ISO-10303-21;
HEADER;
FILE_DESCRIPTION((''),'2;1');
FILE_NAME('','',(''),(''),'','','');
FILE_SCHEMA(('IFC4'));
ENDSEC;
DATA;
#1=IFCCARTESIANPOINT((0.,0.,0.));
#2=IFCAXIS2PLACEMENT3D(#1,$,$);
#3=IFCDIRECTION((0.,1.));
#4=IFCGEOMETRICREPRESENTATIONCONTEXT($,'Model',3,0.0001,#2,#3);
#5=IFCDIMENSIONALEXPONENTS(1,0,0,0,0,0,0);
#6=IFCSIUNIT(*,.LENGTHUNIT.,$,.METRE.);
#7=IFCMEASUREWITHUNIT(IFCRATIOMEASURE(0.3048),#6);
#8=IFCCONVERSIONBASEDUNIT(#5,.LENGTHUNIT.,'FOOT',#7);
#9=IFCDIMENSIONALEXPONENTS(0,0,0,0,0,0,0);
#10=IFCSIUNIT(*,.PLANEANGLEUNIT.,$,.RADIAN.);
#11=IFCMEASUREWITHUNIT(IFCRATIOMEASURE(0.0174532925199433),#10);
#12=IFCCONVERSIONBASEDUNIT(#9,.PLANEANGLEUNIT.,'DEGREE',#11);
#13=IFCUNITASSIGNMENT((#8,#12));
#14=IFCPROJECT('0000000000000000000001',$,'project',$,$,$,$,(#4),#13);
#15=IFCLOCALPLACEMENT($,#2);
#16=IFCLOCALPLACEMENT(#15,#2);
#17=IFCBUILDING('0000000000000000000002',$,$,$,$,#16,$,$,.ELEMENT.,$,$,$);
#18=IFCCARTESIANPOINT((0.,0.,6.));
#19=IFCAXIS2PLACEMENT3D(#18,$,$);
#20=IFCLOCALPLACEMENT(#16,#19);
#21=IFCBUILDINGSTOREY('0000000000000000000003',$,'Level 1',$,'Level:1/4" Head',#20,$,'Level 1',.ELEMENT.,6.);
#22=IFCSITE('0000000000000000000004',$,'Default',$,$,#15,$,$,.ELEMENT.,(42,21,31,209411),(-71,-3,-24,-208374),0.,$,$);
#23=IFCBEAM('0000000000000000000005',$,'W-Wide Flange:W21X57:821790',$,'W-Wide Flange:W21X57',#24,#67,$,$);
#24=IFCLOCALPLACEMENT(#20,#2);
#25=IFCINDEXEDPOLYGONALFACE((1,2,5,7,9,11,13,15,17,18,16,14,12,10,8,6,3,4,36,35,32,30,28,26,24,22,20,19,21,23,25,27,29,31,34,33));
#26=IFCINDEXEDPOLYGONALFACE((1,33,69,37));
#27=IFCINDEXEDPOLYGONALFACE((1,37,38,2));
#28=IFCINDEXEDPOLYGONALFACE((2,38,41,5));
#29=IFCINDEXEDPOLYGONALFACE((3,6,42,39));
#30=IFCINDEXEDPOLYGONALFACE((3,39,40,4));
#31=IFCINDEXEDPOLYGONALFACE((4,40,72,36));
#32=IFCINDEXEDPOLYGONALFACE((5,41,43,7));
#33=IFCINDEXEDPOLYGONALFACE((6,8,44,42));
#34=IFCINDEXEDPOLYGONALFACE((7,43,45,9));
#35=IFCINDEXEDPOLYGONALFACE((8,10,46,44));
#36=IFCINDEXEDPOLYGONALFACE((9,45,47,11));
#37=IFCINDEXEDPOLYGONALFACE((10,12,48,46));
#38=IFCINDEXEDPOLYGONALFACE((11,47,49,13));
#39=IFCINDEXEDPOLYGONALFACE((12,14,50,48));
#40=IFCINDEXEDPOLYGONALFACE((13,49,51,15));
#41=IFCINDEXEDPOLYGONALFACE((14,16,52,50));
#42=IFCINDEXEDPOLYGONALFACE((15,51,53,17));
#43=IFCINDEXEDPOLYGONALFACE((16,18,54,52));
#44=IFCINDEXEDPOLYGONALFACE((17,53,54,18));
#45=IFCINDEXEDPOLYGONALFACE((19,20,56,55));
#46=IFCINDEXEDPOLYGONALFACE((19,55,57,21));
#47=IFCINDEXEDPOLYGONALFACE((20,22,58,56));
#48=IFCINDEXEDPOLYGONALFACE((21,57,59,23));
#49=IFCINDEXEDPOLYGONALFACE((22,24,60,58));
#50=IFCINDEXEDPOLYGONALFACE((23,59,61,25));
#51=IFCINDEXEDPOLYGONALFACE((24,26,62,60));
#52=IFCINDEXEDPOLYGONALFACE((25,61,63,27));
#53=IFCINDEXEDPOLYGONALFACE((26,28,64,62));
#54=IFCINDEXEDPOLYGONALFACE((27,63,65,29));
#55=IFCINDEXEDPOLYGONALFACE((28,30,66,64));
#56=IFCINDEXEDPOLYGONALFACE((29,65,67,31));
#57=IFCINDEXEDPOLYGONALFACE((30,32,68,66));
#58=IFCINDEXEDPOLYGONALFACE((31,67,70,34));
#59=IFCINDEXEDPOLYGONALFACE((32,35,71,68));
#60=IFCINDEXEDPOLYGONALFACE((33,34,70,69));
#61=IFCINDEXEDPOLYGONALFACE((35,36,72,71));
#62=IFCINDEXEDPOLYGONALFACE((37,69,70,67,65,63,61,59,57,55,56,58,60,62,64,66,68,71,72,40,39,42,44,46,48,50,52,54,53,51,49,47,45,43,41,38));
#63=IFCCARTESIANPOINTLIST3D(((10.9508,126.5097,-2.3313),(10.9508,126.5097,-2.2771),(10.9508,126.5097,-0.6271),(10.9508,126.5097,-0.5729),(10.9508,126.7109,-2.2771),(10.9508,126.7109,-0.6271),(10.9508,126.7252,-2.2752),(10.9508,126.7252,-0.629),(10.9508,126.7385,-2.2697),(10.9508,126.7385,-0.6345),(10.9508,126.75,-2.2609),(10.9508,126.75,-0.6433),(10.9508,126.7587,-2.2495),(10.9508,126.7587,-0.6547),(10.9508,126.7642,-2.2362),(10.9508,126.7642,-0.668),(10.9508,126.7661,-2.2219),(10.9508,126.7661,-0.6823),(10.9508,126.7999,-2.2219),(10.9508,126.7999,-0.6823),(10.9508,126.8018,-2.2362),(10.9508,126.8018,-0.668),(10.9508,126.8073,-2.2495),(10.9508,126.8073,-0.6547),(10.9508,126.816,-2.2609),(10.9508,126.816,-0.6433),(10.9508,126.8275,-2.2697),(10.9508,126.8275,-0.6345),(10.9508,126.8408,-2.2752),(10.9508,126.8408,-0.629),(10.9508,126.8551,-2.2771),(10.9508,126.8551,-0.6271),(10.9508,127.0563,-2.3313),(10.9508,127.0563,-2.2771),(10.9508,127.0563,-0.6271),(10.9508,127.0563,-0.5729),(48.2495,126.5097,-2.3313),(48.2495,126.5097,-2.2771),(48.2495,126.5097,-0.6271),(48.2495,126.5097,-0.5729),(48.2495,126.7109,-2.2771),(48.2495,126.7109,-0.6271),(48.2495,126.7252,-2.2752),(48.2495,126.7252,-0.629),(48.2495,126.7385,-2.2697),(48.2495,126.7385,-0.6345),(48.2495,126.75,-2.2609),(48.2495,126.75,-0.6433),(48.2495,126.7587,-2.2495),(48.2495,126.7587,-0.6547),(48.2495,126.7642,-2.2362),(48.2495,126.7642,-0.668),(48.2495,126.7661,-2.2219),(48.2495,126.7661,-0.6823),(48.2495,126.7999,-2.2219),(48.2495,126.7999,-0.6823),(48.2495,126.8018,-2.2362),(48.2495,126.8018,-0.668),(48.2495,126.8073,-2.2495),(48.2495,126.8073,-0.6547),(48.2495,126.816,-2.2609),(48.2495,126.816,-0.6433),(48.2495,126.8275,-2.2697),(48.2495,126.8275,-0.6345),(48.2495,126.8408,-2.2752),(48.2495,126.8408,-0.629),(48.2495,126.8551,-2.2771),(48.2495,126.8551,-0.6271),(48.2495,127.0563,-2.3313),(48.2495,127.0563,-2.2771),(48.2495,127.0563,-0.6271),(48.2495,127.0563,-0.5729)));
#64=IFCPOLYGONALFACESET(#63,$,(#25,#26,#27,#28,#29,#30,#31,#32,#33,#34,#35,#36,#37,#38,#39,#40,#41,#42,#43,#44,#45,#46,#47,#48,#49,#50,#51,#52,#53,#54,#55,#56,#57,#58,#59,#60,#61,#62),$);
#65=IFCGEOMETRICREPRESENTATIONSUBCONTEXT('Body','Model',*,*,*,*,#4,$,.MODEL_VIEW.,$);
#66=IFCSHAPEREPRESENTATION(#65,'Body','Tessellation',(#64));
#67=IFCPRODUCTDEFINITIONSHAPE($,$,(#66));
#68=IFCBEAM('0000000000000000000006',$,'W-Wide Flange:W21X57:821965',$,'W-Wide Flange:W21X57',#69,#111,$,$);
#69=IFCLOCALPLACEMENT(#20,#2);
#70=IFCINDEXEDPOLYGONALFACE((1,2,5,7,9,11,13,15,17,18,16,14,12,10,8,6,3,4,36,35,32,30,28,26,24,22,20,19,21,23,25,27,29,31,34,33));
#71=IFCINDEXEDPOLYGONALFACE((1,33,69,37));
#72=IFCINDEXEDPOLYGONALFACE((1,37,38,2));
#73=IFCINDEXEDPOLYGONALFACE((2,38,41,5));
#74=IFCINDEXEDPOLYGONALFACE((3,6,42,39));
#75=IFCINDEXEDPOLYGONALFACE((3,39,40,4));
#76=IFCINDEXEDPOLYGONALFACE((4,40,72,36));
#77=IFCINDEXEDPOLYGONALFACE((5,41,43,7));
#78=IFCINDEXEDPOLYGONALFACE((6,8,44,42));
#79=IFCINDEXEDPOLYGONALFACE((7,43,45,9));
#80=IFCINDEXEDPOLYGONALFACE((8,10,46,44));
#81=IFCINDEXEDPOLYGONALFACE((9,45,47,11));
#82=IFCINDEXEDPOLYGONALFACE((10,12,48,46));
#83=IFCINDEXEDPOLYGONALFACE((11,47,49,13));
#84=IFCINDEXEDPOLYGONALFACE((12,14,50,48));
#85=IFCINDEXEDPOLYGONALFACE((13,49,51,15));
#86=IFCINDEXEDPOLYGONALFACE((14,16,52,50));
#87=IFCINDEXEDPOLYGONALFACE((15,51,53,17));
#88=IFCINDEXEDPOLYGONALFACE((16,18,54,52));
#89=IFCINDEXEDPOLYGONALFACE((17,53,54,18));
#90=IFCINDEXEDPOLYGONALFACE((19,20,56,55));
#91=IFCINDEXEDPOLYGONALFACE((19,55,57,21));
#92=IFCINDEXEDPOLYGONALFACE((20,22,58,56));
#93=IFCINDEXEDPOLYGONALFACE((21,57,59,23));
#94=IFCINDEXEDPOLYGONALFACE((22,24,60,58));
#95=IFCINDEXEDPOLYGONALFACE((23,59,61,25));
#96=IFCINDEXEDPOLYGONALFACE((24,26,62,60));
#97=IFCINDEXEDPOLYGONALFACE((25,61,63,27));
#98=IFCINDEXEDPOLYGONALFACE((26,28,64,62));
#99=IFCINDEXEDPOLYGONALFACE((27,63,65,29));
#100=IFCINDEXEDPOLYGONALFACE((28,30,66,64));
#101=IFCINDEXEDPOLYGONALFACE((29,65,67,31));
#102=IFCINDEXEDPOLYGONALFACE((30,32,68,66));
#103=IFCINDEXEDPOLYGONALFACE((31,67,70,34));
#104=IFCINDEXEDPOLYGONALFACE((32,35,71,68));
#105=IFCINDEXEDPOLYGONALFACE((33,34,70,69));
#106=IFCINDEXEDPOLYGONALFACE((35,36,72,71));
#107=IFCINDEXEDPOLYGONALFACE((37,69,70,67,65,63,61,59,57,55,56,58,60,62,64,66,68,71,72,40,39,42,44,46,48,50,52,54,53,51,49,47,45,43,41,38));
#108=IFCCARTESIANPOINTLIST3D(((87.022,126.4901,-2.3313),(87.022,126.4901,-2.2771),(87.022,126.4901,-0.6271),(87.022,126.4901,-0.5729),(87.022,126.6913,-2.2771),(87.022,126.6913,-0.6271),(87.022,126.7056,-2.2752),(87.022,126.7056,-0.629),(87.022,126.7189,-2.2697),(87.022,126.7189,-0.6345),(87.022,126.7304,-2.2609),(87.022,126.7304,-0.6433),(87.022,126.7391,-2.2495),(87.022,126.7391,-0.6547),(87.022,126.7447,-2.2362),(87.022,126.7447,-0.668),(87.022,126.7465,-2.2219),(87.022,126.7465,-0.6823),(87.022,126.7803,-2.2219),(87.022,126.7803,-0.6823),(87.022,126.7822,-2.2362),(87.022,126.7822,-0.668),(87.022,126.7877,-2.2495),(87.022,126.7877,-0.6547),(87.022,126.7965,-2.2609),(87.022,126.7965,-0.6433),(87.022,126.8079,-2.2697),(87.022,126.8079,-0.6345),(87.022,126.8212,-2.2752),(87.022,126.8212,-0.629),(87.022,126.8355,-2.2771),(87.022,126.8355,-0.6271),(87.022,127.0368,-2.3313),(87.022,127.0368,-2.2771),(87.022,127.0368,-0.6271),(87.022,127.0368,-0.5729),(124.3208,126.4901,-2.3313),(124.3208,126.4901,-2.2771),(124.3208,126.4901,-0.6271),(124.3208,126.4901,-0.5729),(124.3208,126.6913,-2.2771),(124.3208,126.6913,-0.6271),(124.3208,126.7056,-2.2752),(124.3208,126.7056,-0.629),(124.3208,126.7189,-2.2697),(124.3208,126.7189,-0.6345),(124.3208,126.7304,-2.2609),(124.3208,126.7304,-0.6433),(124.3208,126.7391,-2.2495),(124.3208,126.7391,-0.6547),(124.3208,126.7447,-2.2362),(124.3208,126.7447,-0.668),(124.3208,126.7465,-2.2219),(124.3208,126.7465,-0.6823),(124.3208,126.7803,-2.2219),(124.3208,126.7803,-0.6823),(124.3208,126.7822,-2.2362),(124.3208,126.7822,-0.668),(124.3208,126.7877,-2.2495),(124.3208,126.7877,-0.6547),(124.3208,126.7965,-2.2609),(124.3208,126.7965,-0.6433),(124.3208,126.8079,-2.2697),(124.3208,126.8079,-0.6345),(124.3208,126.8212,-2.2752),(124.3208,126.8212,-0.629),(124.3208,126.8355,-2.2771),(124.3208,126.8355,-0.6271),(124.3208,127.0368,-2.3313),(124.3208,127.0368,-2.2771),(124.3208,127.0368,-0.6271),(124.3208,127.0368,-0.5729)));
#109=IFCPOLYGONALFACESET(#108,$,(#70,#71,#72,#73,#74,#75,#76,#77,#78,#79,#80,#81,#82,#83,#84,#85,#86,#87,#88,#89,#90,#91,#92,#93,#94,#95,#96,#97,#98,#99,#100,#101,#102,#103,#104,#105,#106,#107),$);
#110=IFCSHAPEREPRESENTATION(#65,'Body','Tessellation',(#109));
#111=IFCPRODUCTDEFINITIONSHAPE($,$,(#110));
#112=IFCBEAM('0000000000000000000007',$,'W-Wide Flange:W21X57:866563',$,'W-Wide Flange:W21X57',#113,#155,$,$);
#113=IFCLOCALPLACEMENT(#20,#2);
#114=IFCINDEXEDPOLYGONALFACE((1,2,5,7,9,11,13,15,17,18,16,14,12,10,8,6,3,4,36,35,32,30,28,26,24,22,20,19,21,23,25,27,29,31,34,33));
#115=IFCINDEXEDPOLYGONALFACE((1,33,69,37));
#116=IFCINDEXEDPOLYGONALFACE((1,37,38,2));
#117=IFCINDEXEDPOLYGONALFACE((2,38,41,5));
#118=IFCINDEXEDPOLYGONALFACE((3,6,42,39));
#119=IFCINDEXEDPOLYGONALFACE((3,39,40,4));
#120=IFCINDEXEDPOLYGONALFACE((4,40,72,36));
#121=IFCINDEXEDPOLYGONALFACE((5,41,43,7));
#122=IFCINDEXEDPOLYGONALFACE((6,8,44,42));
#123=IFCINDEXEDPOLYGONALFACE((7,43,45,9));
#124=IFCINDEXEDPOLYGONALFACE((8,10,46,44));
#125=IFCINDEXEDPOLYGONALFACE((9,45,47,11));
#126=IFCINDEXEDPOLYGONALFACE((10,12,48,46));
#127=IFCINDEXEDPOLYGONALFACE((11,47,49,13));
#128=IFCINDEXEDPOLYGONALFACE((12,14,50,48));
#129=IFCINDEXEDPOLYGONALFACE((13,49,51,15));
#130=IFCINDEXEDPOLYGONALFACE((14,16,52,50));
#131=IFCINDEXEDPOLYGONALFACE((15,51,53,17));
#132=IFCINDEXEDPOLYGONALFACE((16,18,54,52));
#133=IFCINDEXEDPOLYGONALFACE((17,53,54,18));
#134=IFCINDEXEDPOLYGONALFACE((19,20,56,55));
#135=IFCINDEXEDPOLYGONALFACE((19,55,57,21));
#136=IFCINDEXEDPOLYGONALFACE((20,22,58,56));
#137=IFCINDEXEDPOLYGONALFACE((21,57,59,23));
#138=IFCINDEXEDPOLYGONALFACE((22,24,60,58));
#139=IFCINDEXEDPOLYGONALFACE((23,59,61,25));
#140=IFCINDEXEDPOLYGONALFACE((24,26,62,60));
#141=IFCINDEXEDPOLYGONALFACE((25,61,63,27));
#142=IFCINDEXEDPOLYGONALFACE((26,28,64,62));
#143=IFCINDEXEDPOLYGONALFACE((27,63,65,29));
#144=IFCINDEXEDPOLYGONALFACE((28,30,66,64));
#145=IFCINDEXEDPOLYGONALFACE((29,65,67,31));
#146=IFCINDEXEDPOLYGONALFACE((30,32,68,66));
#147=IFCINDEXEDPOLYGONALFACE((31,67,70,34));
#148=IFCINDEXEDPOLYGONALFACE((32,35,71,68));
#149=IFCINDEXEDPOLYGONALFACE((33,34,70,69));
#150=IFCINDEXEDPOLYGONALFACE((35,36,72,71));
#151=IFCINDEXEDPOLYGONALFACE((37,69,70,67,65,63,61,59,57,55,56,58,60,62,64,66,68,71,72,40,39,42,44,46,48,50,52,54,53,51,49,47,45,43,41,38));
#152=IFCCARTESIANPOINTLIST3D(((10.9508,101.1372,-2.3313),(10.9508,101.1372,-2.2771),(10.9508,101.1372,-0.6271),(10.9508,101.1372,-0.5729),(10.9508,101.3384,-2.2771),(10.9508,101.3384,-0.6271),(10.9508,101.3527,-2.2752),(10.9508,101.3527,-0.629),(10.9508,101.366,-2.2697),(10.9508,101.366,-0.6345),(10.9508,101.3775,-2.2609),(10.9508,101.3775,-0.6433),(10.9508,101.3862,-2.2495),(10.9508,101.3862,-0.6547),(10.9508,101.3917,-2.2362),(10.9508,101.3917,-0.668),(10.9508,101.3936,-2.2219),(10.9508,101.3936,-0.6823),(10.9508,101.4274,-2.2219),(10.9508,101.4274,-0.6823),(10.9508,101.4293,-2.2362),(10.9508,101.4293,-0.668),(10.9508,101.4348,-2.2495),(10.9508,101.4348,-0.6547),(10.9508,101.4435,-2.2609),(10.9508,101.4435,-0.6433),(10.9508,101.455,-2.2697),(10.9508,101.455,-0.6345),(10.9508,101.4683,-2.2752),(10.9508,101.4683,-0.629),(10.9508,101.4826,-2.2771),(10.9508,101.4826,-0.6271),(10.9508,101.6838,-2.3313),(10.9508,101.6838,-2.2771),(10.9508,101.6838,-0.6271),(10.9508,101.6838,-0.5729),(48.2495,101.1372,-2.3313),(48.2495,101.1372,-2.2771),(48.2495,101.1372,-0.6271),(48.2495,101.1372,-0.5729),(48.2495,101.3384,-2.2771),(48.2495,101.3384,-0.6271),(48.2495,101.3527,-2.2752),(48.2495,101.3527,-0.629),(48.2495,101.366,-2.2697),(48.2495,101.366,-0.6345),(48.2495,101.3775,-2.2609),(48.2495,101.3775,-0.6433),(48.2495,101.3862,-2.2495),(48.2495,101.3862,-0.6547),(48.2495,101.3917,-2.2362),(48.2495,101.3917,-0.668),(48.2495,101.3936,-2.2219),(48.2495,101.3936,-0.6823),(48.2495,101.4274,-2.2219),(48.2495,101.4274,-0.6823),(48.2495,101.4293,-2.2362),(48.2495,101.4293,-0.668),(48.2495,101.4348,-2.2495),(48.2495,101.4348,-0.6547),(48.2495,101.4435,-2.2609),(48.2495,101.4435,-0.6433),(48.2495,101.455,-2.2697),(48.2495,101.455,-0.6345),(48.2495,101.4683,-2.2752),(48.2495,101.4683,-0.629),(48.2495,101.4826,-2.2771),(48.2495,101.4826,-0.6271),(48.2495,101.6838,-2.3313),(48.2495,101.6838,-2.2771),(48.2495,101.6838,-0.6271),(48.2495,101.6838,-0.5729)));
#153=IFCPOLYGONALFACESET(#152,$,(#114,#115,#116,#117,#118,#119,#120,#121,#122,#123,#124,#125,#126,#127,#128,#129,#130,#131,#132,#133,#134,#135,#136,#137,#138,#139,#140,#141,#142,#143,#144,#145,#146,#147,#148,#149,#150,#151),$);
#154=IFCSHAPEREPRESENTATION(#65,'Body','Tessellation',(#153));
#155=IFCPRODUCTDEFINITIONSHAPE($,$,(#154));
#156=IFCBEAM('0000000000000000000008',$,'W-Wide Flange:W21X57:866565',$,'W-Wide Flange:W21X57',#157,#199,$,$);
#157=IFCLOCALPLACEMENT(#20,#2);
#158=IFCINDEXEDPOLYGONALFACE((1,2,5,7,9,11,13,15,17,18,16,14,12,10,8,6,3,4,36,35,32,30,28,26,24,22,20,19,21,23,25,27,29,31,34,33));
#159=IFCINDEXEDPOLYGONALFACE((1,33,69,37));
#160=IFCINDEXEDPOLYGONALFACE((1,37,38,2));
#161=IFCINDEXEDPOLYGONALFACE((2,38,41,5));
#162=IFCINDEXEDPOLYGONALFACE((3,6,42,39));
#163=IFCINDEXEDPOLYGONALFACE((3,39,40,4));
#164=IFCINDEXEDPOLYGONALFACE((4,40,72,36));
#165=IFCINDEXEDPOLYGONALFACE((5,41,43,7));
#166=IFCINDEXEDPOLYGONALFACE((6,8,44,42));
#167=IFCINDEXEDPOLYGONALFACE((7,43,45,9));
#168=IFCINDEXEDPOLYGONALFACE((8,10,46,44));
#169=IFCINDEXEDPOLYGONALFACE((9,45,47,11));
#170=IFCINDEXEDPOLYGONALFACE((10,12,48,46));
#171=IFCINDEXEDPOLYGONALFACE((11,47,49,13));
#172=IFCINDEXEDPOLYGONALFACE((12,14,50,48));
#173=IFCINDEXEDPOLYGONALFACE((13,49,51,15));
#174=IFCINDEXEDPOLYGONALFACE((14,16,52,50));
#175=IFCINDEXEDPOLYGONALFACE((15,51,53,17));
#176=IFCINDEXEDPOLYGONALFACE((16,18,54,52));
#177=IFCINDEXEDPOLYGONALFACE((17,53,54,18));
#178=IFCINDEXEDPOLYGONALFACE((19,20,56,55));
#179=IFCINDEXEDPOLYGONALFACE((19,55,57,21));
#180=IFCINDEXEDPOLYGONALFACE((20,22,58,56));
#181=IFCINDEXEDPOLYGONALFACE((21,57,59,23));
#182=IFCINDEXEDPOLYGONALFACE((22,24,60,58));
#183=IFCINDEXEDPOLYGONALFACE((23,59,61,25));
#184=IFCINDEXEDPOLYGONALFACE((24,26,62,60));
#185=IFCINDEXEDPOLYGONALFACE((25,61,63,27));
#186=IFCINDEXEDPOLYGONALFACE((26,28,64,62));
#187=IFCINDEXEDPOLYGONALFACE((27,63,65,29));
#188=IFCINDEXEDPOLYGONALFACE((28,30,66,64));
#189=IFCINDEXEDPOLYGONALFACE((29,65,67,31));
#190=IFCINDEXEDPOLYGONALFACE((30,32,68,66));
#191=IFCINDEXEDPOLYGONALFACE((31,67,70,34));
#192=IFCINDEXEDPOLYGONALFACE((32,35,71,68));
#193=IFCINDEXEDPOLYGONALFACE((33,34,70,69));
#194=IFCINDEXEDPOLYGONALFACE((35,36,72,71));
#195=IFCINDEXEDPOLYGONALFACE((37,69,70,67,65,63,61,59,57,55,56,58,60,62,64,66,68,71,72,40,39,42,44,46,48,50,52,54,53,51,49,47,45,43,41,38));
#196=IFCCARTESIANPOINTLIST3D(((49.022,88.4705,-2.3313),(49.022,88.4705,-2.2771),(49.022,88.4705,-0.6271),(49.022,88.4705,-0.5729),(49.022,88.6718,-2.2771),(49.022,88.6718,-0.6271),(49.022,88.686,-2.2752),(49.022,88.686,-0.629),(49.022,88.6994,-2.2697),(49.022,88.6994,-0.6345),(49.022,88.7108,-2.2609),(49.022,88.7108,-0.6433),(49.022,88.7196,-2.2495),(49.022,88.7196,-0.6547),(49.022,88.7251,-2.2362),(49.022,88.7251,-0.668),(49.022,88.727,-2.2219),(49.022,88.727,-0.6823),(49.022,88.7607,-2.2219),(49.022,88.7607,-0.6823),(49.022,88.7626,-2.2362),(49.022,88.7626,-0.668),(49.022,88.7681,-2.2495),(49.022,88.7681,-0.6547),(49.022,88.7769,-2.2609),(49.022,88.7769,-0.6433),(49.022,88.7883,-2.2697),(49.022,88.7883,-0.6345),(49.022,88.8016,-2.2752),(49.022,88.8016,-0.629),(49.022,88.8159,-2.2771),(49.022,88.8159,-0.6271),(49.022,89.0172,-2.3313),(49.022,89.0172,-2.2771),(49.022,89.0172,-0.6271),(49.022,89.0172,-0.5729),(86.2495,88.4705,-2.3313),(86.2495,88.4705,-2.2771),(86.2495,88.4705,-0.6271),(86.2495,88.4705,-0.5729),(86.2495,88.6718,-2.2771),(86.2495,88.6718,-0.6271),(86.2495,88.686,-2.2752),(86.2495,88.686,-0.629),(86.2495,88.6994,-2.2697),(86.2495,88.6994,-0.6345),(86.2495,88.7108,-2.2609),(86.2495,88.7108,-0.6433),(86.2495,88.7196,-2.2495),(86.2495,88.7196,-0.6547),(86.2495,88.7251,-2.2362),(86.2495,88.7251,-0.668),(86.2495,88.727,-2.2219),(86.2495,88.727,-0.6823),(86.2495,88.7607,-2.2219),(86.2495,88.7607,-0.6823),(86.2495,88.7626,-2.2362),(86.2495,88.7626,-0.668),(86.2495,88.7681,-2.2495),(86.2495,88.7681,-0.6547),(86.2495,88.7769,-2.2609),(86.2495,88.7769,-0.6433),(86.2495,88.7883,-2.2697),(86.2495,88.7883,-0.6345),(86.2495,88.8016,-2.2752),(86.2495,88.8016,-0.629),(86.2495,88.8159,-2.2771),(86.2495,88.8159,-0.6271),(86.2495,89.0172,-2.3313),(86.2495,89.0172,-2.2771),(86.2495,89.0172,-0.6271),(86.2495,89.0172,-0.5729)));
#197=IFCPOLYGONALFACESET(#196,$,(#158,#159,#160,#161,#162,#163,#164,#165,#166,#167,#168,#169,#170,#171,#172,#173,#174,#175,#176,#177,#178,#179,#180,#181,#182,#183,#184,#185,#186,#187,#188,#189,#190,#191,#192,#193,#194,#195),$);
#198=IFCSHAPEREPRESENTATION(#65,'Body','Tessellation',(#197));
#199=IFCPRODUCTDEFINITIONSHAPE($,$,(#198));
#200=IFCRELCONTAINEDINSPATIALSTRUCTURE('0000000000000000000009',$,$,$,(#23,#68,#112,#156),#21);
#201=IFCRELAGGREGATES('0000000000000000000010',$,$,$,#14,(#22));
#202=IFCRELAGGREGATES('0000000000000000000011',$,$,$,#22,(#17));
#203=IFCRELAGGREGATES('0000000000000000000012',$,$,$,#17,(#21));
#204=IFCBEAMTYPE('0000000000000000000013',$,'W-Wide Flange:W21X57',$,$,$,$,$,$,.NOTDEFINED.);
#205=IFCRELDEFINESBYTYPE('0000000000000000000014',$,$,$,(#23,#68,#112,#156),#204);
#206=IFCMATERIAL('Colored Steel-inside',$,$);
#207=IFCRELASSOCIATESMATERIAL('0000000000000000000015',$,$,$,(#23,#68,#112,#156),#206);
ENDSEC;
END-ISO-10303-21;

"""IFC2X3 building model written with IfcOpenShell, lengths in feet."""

from ifc_helpers import new_model, entity, si_unit, converted_unit, direction, frame, frame_2d, origin, place, context, subcontext, project, spatial, i_section, extrude, material, type_object, element, save


model = new_model("IFC2X3")

# Units and contexts
model_context = context("Model", 3, precision=0.0001, world=origin(), true_north=direction((0.0, 1.0)))
body_context = subcontext(model_context, "Body", "Model", "MODEL_VIEW")
ifc_project = project(units=[converted_unit("LENGTHUNIT", "FOOT", entity("IfcRatioMeasure", 0.3048), si_unit("LENGTHUNIT", "METRE"), dimensions=[1, 0, 0, 0, 0, 0, 0]), converted_unit("PLANEANGLEUNIT", "DEGREE", entity("IfcRatioMeasure", 0.0174532925199433), si_unit("PLANEANGLEUNIT", "RADIAN"), dimensions=[0, 0, 0, 0, 0, 0, 0])], contexts=[model_context])

# Site, building, storey
site_placement = place(None, origin())
site = spatial("IfcSite", under=ifc_project, at=site_placement, Name="Default", CompositionType="ELEMENT", RefLatitude=(42, 21, 31, 209411), RefLongitude=(-71, -3, -24, -208374), RefElevation=0.0)
building_placement = place(site_placement, origin())
building = spatial("IfcBuilding", under=site, at=building_placement, CompositionType="ELEMENT")
storey_placement = place(building_placement, frame((0.0, 0.0, 6.0)))
storey = spatial("IfcBuildingStorey", under=building, at=storey_placement, Name="Level 1", ObjectType="Level:1/4\" Head", LongName="Level 1", CompositionType="ELEMENT", Elevation=6.0)

# Shared definitions
ifc_material_1 = material(Name="Colored Steel-inside")

# Beams
beam_type_1 = type_object("IfcBeamType", Name="W-Wide Flange:W21X57", PredefinedType="NOTDEFINED")
beam_1_placement = place(storey_placement, frame((10.6358, 126.783, 0.0)))
element("IfcBeam", 1, at=beam_1_placement, inside=storey, type_object=beam_type_1, material=ifc_material_1, Name="W-Wide Flange:W21X57:821790", ObjectType="W-Wide Flange:W21X57", context=body_context, shape_type="SweptSolid", body=[
    extrude(i_section(OverallWidth=0.5467, OverallDepth=1.7583, WebThickness=0.0337, FlangeThickness=0.0542, FilletRadius=0.0552, at=frame_2d((0.0, 0.0), x_axis=(0.0, 1.0))), frame((0.315, 0.0, -1.4521), z_axis=(1.0, 0.0, 0.0), x_axis=(0.0, 0.0, -1.0)), (0.0, 0.0, 1.0), 37.2988),
])
beam_2_placement = place(storey_placement, frame((86.6358, 126.7634, 0.0)))
element("IfcBeam", 2, at=beam_2_placement, inside=storey, type_object=beam_type_1, material=ifc_material_1, Name="W-Wide Flange:W21X57:821965", ObjectType="W-Wide Flange:W21X57", context=body_context, shape_type="SweptSolid", body=[
    extrude(i_section(OverallWidth=0.5467, OverallDepth=1.7583, WebThickness=0.0337, FlangeThickness=0.0542, FilletRadius=0.0552, at=frame_2d((0.0, 0.0), x_axis=(0.0, 1.0))), frame((0.3862, 0.0, -1.4521), z_axis=(1.0, 0.0, 0.0), x_axis=(0.0, 0.0, -1.0)), (0.0, 0.0, 1.0), 37.2987),
])
beam_3_placement = place(storey_placement, frame((48.6358, 101.4105, 0.0), z_axis=(0.0, 0.0, 1.0), x_axis=(-1.0, 0.0, 0.0)))
element("IfcBeam", 3, at=beam_3_placement, inside=storey, type_object=beam_type_1, material=ifc_material_1, Name="W-Wide Flange:W21X57:866563", ObjectType="W-Wide Flange:W21X57", context=body_context, shape_type="SweptSolid", body=[
    extrude(i_section(OverallWidth=0.5467, OverallDepth=1.7583, WebThickness=0.0337, FlangeThickness=0.0542, FilletRadius=0.0552, at=frame_2d((0.0, 0.0), x_axis=(0.0, 1.0))), frame((0.3863, 0.0, -1.4521), z_axis=(1.0, 0.0, 0.0), x_axis=(0.0, 0.0, -1.0)), (0.0, 0.0, 1.0), 37.2987),
])
beam_4_placement = place(storey_placement, frame((48.6358, 88.7438, 0.0)))
element("IfcBeam", 4, at=beam_4_placement, inside=storey, type_object=beam_type_1, material=ifc_material_1, Name="W-Wide Flange:W21X57:866565", ObjectType="W-Wide Flange:W21X57", context=body_context, shape_type="SweptSolid", body=[
    extrude(i_section(OverallWidth=0.5467, OverallDepth=1.7583, WebThickness=0.0337, FlangeThickness=0.0542, FilletRadius=0.0552, at=frame_2d((0.0, 0.0), x_axis=(0.0, 1.0))), frame((0.3863, 0.0, -1.4521), z_axis=(1.0, 0.0, 0.0), x_axis=(0.0, 0.0, -1.0)), (0.0, 0.0, 1.0), 37.2275),
])

save(model, "model.ifc")
